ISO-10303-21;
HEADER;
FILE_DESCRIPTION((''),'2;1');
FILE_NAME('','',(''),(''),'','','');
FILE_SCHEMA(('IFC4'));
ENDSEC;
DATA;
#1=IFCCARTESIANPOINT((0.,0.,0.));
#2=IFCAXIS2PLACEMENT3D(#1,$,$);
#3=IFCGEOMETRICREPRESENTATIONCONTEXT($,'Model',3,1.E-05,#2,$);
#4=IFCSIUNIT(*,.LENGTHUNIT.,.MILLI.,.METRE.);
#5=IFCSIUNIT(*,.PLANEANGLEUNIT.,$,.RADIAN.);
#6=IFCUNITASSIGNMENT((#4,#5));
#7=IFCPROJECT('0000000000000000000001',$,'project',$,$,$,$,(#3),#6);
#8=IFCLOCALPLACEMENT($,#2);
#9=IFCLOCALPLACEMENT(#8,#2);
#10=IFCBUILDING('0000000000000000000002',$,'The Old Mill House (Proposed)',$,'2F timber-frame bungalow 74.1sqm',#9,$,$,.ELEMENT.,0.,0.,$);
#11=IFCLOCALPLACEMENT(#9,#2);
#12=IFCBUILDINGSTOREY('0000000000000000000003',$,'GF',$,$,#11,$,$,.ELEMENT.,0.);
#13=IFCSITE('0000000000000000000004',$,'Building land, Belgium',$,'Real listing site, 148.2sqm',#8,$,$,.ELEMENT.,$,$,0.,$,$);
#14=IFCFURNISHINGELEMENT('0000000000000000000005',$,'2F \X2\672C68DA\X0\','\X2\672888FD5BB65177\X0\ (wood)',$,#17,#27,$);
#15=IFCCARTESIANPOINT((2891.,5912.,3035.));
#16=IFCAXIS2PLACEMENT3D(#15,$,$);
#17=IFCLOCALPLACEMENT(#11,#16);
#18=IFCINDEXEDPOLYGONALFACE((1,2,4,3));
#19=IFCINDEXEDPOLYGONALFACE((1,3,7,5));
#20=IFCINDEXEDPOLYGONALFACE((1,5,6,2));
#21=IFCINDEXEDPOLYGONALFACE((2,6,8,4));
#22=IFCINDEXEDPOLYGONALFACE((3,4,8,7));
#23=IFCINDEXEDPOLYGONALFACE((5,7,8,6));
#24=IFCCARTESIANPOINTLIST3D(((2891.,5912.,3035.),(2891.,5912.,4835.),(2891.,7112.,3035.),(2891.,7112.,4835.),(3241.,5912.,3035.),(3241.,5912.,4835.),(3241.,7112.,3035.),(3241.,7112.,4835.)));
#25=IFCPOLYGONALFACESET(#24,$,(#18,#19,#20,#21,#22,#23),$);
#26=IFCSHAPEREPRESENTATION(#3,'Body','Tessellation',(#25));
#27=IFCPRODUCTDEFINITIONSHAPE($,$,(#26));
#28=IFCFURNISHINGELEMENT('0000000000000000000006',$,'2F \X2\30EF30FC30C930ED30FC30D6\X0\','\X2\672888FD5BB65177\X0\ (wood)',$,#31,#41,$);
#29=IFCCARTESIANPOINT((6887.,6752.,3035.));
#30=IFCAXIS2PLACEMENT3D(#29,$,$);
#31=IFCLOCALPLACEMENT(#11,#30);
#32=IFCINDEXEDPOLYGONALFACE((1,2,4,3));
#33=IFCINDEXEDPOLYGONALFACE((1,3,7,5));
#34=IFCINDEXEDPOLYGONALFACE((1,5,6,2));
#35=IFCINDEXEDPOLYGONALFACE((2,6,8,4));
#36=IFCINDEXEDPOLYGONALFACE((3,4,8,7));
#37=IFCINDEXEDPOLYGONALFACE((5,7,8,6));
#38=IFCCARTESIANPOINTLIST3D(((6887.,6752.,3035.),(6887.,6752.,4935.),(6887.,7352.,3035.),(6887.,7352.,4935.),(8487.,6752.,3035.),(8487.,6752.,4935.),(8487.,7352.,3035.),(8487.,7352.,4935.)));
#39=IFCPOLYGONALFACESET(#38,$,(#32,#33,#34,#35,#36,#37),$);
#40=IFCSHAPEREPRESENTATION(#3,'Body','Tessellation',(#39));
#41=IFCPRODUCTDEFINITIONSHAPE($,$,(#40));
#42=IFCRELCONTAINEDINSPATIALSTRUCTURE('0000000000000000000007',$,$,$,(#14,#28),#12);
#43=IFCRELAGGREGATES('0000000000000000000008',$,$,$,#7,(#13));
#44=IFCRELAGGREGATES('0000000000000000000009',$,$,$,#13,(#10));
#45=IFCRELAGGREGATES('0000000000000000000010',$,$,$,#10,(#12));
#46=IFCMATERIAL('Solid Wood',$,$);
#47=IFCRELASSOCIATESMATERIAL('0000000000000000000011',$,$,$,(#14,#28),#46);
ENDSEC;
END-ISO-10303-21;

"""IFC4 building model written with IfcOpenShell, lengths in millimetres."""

from ifc_helpers import new_model, si_unit, frame, frame_2d, origin, place, context, project, spatial, rectangle, extrude, material, element, save


model = new_model("IFC4")

# Units and contexts
model_context = context("Model", 3, precision=1e-05, world=origin())
ifc_project = project(units=[si_unit("LENGTHUNIT", "METRE", prefix="MILLI"), si_unit("PLANEANGLEUNIT", "RADIAN")], contexts=[model_context])

# Site, building, storey
site_placement = place(None, origin())
site = spatial("IfcSite", under=ifc_project, at=site_placement, Name="Building land, Belgium", ObjectType="Real listing site, 148.2sqm", CompositionType="ELEMENT", RefElevation=0.0)
building_placement = place(site_placement, origin())
building = spatial("IfcBuilding", under=site, at=building_placement, Name="The Old Mill House (Proposed)", ObjectType="2F timber-frame bungalow 74.1sqm", CompositionType="ELEMENT", ElevationOfRefHeight=0.0, ElevationOfTerrain=0.0)
storey_placement = place(building_placement, origin())
storey = spatial("IfcBuildingStorey", under=building, at=storey_placement, Name="GF", CompositionType="ELEMENT", Elevation=0.0)

# Shared definitions
ifc_material_1 = material(Name="Solid Wood")

# Furnishing elements
furnishing_1_placement = place(storey_placement, frame((2891.0, 5912.0, 3035.0)))
element("IfcFurnishingElement", 1, at=furnishing_1_placement, inside=storey, material=ifc_material_1, Name="2F 本棚", Description="木製家具 (wood)", context=model_context, shape_type="SweptSolid", body=[
    extrude(rectangle(XDim=350.0, YDim=1200.0, at=frame_2d((175.0, 600.0))), frame((2891.0, 5912.0, 3035.0)), (0.0, 0.0, 1.0), 1800.0),
])
furnishing_2_placement = place(storey_placement, frame((6887.0, 6752.0, 3035.0)))
element("IfcFurnishingElement", 2, at=furnishing_2_placement, inside=storey, material=ifc_material_1, Name="2F ワードローブ", Description="木製家具 (wood)", context=model_context, shape_type="SweptSolid", body=[
    extrude(rectangle(XDim=1600.0, YDim=600.0, at=frame_2d((800.0, 300.0))), frame((6887.0, 6752.0, 3035.0)), (0.0, 0.0, 1.0), 1900.0),
])

save(model, "model.ifc")
